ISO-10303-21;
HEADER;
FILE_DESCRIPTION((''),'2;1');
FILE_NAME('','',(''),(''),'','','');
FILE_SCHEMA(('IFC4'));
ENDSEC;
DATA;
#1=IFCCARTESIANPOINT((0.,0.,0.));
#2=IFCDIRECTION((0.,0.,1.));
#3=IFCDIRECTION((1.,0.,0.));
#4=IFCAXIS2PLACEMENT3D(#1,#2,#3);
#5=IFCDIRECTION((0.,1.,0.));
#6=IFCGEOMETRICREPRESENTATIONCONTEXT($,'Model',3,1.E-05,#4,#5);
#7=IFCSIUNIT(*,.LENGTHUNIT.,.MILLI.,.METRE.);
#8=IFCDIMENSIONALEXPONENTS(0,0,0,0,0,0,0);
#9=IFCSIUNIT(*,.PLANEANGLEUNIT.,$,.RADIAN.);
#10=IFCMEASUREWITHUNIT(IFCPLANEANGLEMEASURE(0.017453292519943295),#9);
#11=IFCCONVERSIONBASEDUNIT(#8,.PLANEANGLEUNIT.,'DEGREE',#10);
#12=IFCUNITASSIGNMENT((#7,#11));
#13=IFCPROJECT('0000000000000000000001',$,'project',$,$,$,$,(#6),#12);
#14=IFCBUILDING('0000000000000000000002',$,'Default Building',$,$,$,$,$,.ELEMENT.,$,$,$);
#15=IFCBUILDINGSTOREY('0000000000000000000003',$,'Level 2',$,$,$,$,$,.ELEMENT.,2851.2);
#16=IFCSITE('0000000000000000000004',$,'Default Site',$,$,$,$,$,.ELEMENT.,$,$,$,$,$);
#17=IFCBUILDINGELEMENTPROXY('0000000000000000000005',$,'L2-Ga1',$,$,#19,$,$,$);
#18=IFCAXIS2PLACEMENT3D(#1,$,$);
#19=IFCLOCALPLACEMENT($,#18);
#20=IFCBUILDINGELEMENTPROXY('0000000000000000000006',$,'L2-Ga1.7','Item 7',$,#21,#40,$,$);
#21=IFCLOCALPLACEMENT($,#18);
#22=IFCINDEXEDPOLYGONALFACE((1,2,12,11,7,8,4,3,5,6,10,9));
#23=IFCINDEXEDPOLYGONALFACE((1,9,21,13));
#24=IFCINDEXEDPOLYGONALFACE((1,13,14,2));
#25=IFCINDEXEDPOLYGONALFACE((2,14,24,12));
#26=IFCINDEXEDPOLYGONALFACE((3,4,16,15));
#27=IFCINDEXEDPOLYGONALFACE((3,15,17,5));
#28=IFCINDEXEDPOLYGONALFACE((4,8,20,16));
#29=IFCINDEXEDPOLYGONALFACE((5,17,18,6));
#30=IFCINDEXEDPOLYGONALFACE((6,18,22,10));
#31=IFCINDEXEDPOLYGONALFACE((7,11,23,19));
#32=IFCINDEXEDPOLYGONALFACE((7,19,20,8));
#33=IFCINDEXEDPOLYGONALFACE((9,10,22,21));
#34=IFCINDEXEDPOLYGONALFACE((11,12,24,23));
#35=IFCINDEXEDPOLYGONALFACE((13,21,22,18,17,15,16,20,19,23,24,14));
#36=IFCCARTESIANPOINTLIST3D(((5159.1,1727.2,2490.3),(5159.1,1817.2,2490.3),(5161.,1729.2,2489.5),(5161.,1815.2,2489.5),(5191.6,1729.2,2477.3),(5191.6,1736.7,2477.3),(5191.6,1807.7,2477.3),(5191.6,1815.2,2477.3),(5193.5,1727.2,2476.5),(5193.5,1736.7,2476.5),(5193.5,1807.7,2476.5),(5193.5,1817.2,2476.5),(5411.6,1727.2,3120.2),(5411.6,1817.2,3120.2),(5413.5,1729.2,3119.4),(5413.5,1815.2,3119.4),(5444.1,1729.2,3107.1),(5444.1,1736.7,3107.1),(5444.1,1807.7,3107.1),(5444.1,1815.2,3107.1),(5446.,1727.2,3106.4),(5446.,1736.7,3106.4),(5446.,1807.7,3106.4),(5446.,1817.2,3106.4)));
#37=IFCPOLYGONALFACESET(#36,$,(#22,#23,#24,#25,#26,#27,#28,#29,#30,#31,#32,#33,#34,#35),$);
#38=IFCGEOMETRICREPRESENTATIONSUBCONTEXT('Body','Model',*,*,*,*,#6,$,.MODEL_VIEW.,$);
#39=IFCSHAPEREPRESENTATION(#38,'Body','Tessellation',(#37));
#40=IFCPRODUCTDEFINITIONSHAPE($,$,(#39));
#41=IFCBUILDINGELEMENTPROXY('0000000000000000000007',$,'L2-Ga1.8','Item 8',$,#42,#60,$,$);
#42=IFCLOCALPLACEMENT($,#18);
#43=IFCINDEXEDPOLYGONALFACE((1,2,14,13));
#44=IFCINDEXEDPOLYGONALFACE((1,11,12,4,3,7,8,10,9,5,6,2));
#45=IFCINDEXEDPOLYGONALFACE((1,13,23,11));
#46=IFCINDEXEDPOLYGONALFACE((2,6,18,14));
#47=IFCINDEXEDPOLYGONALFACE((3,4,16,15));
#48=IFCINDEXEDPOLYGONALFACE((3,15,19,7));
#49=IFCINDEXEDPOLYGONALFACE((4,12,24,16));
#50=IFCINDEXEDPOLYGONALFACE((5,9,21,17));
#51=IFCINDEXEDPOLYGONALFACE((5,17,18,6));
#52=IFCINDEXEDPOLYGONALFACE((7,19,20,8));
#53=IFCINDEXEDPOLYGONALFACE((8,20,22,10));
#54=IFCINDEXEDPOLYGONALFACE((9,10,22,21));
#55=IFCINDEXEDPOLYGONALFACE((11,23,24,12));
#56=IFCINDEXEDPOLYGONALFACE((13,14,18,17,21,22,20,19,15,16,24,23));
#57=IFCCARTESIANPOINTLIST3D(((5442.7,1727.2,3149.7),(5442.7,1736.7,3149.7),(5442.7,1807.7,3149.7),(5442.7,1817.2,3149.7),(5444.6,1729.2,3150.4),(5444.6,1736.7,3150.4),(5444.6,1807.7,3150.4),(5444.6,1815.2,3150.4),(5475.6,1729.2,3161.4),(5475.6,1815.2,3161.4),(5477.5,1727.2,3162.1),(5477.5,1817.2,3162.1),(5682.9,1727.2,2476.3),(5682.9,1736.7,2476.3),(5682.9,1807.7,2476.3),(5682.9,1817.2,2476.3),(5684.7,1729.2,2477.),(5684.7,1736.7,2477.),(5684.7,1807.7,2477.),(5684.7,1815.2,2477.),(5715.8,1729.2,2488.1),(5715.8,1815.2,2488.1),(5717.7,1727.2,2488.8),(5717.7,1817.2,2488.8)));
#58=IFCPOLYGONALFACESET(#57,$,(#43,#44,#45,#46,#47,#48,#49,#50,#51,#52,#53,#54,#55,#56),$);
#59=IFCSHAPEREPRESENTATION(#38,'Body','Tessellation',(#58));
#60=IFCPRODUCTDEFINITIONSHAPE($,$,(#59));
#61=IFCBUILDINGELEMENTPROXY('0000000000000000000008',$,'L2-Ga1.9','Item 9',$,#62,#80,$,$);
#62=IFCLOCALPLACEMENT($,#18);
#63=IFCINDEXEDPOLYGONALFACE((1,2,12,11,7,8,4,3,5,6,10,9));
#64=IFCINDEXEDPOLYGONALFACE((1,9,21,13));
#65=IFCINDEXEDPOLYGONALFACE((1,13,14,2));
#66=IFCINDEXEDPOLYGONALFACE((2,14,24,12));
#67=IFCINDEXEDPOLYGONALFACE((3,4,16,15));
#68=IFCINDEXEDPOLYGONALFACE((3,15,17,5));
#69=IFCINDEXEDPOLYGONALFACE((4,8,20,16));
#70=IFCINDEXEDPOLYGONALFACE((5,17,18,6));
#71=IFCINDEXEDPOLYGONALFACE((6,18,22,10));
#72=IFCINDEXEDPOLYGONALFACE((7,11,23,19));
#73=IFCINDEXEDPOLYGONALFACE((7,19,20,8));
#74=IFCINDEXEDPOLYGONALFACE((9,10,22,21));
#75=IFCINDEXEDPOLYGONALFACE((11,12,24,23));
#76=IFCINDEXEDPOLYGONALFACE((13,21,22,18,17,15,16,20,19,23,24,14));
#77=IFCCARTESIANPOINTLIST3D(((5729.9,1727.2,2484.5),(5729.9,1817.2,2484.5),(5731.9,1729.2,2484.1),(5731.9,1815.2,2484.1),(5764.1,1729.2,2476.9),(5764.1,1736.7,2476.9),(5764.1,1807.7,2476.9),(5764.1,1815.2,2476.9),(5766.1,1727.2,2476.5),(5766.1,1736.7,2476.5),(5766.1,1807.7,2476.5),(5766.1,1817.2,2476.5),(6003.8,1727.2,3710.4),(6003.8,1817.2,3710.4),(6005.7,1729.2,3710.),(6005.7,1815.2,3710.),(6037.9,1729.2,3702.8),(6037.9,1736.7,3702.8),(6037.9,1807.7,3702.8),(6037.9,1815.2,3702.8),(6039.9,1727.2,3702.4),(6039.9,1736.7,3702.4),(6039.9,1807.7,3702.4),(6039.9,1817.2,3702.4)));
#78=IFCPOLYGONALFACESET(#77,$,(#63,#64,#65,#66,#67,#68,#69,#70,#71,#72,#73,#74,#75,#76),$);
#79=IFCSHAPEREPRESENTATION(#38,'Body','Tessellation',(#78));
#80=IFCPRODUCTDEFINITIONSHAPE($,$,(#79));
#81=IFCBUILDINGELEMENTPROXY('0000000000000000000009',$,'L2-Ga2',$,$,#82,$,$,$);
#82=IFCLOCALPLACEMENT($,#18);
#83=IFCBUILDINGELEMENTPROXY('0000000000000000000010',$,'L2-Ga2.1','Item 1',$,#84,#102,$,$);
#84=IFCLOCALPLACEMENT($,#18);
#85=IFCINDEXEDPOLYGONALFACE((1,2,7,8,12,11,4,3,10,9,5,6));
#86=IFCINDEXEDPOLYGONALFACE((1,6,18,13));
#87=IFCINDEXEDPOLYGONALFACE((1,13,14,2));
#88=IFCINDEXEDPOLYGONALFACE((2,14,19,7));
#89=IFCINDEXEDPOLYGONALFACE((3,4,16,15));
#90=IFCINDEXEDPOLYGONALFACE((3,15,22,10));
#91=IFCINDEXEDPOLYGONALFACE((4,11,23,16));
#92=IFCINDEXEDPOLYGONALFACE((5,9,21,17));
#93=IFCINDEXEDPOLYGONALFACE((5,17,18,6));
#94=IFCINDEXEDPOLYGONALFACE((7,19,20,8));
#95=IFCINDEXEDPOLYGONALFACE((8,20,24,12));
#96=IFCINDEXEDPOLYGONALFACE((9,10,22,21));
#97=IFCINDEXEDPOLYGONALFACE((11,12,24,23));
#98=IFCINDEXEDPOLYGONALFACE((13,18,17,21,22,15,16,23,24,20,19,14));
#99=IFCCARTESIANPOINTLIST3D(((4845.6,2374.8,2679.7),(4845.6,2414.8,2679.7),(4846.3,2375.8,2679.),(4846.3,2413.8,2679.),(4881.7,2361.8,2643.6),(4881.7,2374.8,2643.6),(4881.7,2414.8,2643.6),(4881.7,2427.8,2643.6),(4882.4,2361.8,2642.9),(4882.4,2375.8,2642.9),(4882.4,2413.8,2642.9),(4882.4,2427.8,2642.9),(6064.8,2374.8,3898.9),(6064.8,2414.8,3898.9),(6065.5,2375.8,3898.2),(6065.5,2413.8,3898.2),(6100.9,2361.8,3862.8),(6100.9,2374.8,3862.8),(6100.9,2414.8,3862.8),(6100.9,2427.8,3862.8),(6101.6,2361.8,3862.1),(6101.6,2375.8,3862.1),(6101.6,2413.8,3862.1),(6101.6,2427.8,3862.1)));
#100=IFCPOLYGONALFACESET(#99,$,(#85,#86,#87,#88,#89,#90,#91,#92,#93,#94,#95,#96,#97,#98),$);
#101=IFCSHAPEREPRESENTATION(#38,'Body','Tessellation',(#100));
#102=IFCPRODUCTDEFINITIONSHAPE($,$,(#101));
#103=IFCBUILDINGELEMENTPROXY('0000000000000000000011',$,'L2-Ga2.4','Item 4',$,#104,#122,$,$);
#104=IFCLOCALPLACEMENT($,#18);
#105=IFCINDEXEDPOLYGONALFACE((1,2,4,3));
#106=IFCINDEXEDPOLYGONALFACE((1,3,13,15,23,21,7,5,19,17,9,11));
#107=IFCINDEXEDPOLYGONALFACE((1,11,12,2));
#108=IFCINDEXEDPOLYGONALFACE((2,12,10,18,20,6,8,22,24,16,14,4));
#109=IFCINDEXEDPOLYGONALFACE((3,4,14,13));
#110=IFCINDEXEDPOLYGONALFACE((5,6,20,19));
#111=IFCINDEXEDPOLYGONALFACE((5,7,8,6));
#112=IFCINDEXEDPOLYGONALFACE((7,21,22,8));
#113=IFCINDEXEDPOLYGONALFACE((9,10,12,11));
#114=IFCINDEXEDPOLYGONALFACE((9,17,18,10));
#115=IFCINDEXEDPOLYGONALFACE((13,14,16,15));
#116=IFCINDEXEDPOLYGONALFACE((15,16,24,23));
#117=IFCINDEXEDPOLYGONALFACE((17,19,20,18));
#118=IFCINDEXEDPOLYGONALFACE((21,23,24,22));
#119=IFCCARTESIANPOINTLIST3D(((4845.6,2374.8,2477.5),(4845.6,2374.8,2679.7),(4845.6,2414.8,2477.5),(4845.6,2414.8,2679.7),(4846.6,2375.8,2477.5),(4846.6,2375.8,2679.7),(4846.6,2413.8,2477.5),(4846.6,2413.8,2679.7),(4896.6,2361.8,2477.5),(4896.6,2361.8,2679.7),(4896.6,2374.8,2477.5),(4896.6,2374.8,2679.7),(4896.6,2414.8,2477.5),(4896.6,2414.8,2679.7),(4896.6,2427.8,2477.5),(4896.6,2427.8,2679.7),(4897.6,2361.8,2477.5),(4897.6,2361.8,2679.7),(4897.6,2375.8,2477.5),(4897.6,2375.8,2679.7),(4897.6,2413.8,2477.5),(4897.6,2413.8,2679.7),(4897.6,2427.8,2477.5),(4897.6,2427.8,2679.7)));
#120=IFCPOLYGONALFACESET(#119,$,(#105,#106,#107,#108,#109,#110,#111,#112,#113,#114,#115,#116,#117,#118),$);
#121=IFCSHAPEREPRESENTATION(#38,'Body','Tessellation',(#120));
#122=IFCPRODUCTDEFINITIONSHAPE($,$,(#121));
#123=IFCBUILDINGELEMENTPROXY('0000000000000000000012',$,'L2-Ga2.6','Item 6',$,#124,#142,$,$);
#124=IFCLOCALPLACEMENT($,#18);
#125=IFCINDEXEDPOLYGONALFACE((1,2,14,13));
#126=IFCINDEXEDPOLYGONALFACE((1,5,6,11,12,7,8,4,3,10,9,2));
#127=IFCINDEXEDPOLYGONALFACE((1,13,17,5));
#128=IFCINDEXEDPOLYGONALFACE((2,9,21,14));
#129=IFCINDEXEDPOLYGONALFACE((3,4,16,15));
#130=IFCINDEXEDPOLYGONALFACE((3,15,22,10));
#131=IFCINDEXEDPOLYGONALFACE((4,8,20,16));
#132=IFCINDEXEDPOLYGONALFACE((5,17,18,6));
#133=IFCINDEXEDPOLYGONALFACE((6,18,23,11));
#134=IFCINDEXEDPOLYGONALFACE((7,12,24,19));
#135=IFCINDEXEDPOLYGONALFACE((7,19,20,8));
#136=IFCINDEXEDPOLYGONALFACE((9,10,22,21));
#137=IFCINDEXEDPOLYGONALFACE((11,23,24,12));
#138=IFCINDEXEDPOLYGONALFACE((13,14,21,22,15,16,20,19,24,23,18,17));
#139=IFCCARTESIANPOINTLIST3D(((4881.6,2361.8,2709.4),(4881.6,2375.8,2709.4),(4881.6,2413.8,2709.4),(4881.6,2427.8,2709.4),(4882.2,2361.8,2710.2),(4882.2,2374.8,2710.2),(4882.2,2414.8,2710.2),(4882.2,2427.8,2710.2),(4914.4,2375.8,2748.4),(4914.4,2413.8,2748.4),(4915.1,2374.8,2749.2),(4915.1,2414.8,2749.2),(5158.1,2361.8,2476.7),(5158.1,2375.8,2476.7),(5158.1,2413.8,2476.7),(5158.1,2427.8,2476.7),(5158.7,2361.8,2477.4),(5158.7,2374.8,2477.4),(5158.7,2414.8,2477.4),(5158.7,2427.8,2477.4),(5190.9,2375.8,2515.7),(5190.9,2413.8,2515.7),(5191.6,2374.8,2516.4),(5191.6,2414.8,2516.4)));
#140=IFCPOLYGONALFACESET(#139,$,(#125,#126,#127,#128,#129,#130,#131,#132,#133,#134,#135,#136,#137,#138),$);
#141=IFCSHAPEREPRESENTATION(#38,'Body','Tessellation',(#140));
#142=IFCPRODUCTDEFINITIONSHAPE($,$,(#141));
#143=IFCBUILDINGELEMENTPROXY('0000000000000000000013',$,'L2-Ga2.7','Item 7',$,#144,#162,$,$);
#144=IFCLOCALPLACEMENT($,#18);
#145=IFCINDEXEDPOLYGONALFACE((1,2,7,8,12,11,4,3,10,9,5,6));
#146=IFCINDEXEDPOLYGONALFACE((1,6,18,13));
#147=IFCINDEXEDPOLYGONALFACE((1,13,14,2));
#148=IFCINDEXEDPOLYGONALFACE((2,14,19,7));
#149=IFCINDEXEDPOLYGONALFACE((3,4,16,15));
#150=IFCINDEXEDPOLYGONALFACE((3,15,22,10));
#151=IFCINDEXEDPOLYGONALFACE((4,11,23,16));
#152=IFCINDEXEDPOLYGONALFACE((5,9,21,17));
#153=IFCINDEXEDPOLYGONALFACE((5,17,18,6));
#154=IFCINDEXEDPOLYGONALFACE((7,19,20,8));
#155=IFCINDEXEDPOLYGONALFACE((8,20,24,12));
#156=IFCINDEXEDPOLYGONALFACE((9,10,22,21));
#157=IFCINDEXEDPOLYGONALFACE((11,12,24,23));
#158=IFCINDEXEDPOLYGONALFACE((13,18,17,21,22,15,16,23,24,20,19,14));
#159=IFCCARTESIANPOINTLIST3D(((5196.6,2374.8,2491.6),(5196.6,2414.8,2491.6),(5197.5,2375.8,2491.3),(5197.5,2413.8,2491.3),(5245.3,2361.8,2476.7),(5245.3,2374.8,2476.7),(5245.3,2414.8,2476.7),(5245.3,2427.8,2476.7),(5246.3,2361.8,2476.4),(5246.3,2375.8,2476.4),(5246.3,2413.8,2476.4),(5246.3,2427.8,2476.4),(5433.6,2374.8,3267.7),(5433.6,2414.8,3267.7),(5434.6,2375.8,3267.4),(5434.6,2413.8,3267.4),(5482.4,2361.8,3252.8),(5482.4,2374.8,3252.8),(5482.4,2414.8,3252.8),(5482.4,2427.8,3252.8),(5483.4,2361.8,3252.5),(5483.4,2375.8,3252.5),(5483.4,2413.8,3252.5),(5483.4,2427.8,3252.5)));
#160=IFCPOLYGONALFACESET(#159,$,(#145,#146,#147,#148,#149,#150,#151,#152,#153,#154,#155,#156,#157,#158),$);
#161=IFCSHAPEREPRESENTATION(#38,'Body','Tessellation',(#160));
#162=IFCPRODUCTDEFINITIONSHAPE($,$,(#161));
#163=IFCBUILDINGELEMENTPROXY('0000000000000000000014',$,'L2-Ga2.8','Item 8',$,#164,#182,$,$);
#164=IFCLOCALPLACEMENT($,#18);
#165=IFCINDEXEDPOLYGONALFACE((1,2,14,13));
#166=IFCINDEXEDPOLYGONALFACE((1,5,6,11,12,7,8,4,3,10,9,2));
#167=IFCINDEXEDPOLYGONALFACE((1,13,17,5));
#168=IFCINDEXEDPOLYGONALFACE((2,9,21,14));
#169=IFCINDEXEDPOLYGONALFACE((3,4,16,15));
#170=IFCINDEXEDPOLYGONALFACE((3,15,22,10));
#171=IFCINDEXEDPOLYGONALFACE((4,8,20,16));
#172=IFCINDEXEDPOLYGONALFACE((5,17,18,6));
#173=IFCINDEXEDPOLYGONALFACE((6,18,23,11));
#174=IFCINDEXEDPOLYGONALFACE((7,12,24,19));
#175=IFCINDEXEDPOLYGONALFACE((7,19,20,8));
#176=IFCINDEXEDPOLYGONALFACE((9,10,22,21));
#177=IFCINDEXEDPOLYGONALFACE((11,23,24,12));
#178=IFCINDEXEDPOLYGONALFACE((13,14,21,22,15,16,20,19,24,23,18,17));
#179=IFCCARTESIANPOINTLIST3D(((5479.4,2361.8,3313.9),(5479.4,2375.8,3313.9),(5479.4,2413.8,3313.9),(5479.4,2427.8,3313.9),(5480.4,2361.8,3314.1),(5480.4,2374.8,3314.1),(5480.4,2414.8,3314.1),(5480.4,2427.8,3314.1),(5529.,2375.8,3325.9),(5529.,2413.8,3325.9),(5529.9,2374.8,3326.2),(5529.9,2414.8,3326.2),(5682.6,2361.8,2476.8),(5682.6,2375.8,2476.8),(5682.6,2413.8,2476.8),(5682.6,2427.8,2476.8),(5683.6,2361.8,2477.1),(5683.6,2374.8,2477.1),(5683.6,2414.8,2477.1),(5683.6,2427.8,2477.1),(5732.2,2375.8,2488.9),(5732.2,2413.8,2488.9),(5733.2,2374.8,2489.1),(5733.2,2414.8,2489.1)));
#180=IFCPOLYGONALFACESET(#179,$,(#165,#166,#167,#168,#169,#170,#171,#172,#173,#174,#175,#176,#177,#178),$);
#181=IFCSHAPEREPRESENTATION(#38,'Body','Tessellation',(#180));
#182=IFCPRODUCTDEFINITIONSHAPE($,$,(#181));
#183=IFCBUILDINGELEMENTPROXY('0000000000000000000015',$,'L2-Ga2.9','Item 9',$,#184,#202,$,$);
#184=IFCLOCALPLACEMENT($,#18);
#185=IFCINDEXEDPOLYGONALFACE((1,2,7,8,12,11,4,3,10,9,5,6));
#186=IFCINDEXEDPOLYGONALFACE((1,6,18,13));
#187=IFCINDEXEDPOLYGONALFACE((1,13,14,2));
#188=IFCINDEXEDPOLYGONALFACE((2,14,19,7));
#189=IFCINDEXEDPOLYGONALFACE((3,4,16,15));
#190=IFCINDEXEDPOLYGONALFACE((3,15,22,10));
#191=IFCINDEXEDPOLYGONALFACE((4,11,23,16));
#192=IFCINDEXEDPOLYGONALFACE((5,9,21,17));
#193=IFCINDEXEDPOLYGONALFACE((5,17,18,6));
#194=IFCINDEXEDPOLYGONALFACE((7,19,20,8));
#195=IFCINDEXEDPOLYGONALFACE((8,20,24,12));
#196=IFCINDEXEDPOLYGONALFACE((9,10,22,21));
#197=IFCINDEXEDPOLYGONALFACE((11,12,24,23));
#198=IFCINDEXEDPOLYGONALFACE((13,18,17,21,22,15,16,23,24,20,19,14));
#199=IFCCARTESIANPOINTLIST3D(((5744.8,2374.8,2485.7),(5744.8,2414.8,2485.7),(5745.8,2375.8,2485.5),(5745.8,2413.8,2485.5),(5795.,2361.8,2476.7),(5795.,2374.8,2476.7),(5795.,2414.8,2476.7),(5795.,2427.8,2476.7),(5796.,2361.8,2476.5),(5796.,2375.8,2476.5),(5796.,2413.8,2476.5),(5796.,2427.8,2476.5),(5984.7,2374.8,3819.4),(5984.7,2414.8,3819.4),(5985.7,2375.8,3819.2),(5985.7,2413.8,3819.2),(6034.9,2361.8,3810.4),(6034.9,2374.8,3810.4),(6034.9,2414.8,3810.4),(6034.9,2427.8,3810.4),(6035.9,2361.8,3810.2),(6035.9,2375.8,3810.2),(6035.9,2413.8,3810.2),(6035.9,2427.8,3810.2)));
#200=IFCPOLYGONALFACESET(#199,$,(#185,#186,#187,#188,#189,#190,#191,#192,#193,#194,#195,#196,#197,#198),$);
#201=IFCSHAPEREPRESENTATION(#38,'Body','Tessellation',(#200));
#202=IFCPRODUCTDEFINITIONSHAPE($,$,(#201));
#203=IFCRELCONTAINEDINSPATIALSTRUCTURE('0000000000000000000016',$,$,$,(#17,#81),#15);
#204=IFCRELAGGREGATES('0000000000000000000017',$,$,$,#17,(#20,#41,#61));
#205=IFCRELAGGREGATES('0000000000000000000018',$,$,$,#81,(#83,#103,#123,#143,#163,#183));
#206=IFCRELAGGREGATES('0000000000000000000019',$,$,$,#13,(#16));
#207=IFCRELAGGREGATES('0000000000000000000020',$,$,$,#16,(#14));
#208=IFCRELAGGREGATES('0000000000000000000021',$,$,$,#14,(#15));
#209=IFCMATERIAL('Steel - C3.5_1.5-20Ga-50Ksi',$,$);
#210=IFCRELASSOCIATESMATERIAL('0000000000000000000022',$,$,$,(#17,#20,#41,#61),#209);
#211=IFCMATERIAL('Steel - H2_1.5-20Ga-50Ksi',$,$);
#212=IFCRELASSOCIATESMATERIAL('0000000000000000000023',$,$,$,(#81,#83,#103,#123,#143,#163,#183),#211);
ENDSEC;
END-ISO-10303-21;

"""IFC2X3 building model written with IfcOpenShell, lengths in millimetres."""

from ifc_helpers import new_model, entity, si_unit, converted_unit, direction, frame, origin, origin_with_axes, origin_2d_with_axis, place, context, subcontext, project, spatial, polyline, c_section, outline, extrude, material, element, aggregate, save


model = new_model("IFC2X3")

# Units and contexts
model_context = context("Model", 3, precision=1e-05, world=origin_with_axes(), true_north=direction((0.0, 1.0, 0.0)))
body_context = subcontext(model_context, "Body", "Model", "MODEL_VIEW")
ifc_project = project(units=[si_unit("LENGTHUNIT", "METRE", prefix="MILLI"), converted_unit("PLANEANGLEUNIT", "DEGREE", entity("IfcPlaneAngleMeasure", 0.017453292519943295), si_unit("PLANEANGLEUNIT", "RADIAN"), dimensions=[0, 0, 0, 0, 0, 0, 0])], contexts=[model_context])

# Site, building, storey
site = spatial("IfcSite", under=ifc_project, Name="Default Site", CompositionType="ELEMENT")
building = spatial("IfcBuilding", under=site, Name="Default Building", CompositionType="ELEMENT")
storey = spatial("IfcBuildingStorey", under=building, Name="Level 2", CompositionType="ELEMENT", Elevation=2851.2)

# Shared definitions
ifc_material_1 = material(Name="Steel - C3.5_1.5-20Ga-50Ksi")

# Building element proxies
proxy_1 = element("IfcBuildingElementProxy", 1, inside=storey, material=ifc_material_1, Name="L2-Ga1")
proxy_2_placement = place(None, frame((5176.3, 1772.2, 2483.4), z_axis=(0.372, 0.0, 0.928), x_axis=(34.34, 0.0, -13.777)))
proxy_2 = element("IfcBuildingElementProxy", 2, at=proxy_2_placement, material=ifc_material_1, Name="L2-Ga1.7", Description="Item 7", context=body_context, shape_type="SweptSolid", body=[
    extrude(c_section(Depth=90.0, Width=37.0, WallThickness=2.0, Girth=9.5, at=origin_2d_with_axis()), origin(), (0.0, 0.0, 1.0), 678.6),
])
proxy_3_placement = place(None, frame((5460.1, 1772.2, 3155.9), z_axis=(0.336, 0.0, -0.942), x_axis=(-34.844, 0.0, -12.447)))
proxy_3 = element("IfcBuildingElementProxy", 3, at=proxy_3_placement, material=ifc_material_1, Name="L2-Ga1.8", Description="Item 8", context=body_context, shape_type="SweptSolid", body=[
    extrude(c_section(Depth=90.0, Width=37.0, WallThickness=2.0, Girth=9.5, at=origin_2d_with_axis()), origin(), (0.0, 0.0, 1.0), 714.9),
])
proxy_4_placement = place(None, frame((5748.0, 1772.2, 2480.5), z_axis=(0.218, 0.0, 0.976), x_axis=(36.113, 0.0, -8.054)))
proxy_4 = element("IfcBuildingElementProxy", 4, at=proxy_4_placement, material=ifc_material_1, Name="L2-Ga1.9", Description="Item 9", context=body_context, shape_type="SweptSolid", body=[
    extrude(c_section(Depth=90.0, Width=37.0, WallThickness=2.0, Girth=9.5, at=origin_2d_with_axis()), origin(), (0.0, 0.0, 1.0), 1256.1),
])
aggregate(proxy_1, [proxy_2, proxy_3, proxy_4])
ifc_material_2 = material(Name="Steel - H2_1.5-20Ga-50Ksi")
proxy_5 = element("IfcBuildingElementProxy", 5, inside=storey, material=ifc_material_2, Name="L2-Ga2")
proxy_6_placement = place(None, frame((4882.4, 2361.8, 2642.9), z_axis=(0.707, 0.0, 0.707), x_axis=(0.0, 40.0, 0.0)))
proxy_6 = element("IfcBuildingElementProxy", 6, at=proxy_6_placement, material=ifc_material_2, Name="L2-Ga2.1", Description="Item 1", context=body_context, shape_type="SweptSolid", body=[
    extrude(outline(polyline([(0.0, 0.0), (14.0, 0.0), (14.0, 51.0), (52.0, 51.0), (52.0, 0.0), (66.0, 0.0), (66.0, 1.0), (53.0, 1.0), (53.0, 52.0), (13.0, 52.0), (13.0, 1.0), (0.0, 1.0), (0.0, 0.0)])), origin(), (0.0, 0.0, 1.0), 1724.2),
])
proxy_7_placement = place(None, frame((4897.6, 2361.8, 2477.5), z_axis=(0.0, 0.0, 1.0), x_axis=(0.0, 40.0, 0.0)))
proxy_7 = element("IfcBuildingElementProxy", 7, at=proxy_7_placement, material=ifc_material_2, Name="L2-Ga2.4", Description="Item 4", context=body_context, shape_type="SweptSolid", body=[
    extrude(outline(polyline([(0.0, 0.0), (14.0, 0.0), (14.0, 51.0), (52.0, 51.0), (52.0, 0.0), (66.0, 0.0), (66.0, 1.0), (53.0, 1.0), (53.0, 52.0), (13.0, 52.0), (13.0, 1.0), (0.0, 1.0), (0.0, 0.0)])), origin(), (0.0, 0.0, 1.0), 202.2),
])
proxy_8_placement = place(None, frame((4881.6, 2361.8, 2709.4), z_axis=(0.765, 0.0, -0.644), x_axis=(0.0, 40.0, 0.0)))
proxy_8 = element("IfcBuildingElementProxy", 8, at=proxy_8_placement, material=ifc_material_2, Name="L2-Ga2.6", Description="Item 6", context=body_context, shape_type="SweptSolid", body=[
    extrude(outline(polyline([(0.0, 0.0), (14.0, 0.0), (14.0, 51.0), (52.0, 51.0), (52.0, 0.0), (66.0, 0.0), (66.0, 1.0), (53.0, 1.0), (53.0, 52.0), (13.0, 52.0), (13.0, 1.0), (0.0, 1.0), (0.0, 0.0)])), origin(), (0.0, 0.0, 1.0), 361.4),
])
proxy_9_placement = place(None, frame((5246.3, 2361.8, 2476.4), z_axis=(0.292, 0.0, 0.956), x_axis=(0.0, 40.0, 0.0)))
proxy_9 = element("IfcBuildingElementProxy", 9, at=proxy_9_placement, material=ifc_material_2, Name="L2-Ga2.7", Description="Item 7", context=body_context, shape_type="SweptSolid", body=[
    extrude(outline(polyline([(0.0, 0.0), (14.0, 0.0), (14.0, 51.0), (52.0, 51.0), (52.0, 0.0), (66.0, 0.0), (66.0, 1.0), (53.0, 1.0), (53.0, 52.0), (13.0, 52.0), (13.0, 1.0), (0.0, 1.0), (0.0, 0.0)])), origin(), (0.0, 0.0, 1.0), 811.5),
])
proxy_10_placement = place(None, frame((5479.4, 2361.8, 3313.9), z_axis=(0.236, 0.0, -0.972), x_axis=(0.0, 40.0, 0.0)))
proxy_10 = element("IfcBuildingElementProxy", 10, at=proxy_10_placement, material=ifc_material_2, Name="L2-Ga2.8", Description="Item 8", context=body_context, shape_type="SweptSolid", body=[
    extrude(outline(polyline([(0.0, 0.0), (14.0, 0.0), (14.0, 51.0), (52.0, 51.0), (52.0, 0.0), (66.0, 0.0), (66.0, 1.0), (53.0, 1.0), (53.0, 52.0), (13.0, 52.0), (13.0, 1.0), (0.0, 1.0), (0.0, 0.0)])), origin(), (0.0, 0.0, 1.0), 861.4),
])
proxy_11_placement = place(None, frame((5796.0, 2361.8, 2476.5), z_axis=(0.177, 0.0, 0.984), x_axis=(0.0, 40.0, 0.0)))
proxy_11 = element("IfcBuildingElementProxy", 11, at=proxy_11_placement, material=ifc_material_2, Name="L2-Ga2.9", Description="Item 9", context=body_context, shape_type="SweptSolid", body=[
    extrude(outline(polyline([(0.0, 0.0), (14.0, 0.0), (14.0, 51.0), (52.0, 51.0), (52.0, 0.0), (66.0, 0.0), (66.0, 1.0), (53.0, 1.0), (53.0, 52.0), (13.0, 52.0), (13.0, 1.0), (0.0, 1.0), (0.0, 0.0)])), origin(), (0.0, 0.0, 1.0), 1355.1),
])
aggregate(proxy_5, [proxy_6, proxy_7, proxy_8, proxy_9, proxy_10, proxy_11])

save(model, "model.ifc")
